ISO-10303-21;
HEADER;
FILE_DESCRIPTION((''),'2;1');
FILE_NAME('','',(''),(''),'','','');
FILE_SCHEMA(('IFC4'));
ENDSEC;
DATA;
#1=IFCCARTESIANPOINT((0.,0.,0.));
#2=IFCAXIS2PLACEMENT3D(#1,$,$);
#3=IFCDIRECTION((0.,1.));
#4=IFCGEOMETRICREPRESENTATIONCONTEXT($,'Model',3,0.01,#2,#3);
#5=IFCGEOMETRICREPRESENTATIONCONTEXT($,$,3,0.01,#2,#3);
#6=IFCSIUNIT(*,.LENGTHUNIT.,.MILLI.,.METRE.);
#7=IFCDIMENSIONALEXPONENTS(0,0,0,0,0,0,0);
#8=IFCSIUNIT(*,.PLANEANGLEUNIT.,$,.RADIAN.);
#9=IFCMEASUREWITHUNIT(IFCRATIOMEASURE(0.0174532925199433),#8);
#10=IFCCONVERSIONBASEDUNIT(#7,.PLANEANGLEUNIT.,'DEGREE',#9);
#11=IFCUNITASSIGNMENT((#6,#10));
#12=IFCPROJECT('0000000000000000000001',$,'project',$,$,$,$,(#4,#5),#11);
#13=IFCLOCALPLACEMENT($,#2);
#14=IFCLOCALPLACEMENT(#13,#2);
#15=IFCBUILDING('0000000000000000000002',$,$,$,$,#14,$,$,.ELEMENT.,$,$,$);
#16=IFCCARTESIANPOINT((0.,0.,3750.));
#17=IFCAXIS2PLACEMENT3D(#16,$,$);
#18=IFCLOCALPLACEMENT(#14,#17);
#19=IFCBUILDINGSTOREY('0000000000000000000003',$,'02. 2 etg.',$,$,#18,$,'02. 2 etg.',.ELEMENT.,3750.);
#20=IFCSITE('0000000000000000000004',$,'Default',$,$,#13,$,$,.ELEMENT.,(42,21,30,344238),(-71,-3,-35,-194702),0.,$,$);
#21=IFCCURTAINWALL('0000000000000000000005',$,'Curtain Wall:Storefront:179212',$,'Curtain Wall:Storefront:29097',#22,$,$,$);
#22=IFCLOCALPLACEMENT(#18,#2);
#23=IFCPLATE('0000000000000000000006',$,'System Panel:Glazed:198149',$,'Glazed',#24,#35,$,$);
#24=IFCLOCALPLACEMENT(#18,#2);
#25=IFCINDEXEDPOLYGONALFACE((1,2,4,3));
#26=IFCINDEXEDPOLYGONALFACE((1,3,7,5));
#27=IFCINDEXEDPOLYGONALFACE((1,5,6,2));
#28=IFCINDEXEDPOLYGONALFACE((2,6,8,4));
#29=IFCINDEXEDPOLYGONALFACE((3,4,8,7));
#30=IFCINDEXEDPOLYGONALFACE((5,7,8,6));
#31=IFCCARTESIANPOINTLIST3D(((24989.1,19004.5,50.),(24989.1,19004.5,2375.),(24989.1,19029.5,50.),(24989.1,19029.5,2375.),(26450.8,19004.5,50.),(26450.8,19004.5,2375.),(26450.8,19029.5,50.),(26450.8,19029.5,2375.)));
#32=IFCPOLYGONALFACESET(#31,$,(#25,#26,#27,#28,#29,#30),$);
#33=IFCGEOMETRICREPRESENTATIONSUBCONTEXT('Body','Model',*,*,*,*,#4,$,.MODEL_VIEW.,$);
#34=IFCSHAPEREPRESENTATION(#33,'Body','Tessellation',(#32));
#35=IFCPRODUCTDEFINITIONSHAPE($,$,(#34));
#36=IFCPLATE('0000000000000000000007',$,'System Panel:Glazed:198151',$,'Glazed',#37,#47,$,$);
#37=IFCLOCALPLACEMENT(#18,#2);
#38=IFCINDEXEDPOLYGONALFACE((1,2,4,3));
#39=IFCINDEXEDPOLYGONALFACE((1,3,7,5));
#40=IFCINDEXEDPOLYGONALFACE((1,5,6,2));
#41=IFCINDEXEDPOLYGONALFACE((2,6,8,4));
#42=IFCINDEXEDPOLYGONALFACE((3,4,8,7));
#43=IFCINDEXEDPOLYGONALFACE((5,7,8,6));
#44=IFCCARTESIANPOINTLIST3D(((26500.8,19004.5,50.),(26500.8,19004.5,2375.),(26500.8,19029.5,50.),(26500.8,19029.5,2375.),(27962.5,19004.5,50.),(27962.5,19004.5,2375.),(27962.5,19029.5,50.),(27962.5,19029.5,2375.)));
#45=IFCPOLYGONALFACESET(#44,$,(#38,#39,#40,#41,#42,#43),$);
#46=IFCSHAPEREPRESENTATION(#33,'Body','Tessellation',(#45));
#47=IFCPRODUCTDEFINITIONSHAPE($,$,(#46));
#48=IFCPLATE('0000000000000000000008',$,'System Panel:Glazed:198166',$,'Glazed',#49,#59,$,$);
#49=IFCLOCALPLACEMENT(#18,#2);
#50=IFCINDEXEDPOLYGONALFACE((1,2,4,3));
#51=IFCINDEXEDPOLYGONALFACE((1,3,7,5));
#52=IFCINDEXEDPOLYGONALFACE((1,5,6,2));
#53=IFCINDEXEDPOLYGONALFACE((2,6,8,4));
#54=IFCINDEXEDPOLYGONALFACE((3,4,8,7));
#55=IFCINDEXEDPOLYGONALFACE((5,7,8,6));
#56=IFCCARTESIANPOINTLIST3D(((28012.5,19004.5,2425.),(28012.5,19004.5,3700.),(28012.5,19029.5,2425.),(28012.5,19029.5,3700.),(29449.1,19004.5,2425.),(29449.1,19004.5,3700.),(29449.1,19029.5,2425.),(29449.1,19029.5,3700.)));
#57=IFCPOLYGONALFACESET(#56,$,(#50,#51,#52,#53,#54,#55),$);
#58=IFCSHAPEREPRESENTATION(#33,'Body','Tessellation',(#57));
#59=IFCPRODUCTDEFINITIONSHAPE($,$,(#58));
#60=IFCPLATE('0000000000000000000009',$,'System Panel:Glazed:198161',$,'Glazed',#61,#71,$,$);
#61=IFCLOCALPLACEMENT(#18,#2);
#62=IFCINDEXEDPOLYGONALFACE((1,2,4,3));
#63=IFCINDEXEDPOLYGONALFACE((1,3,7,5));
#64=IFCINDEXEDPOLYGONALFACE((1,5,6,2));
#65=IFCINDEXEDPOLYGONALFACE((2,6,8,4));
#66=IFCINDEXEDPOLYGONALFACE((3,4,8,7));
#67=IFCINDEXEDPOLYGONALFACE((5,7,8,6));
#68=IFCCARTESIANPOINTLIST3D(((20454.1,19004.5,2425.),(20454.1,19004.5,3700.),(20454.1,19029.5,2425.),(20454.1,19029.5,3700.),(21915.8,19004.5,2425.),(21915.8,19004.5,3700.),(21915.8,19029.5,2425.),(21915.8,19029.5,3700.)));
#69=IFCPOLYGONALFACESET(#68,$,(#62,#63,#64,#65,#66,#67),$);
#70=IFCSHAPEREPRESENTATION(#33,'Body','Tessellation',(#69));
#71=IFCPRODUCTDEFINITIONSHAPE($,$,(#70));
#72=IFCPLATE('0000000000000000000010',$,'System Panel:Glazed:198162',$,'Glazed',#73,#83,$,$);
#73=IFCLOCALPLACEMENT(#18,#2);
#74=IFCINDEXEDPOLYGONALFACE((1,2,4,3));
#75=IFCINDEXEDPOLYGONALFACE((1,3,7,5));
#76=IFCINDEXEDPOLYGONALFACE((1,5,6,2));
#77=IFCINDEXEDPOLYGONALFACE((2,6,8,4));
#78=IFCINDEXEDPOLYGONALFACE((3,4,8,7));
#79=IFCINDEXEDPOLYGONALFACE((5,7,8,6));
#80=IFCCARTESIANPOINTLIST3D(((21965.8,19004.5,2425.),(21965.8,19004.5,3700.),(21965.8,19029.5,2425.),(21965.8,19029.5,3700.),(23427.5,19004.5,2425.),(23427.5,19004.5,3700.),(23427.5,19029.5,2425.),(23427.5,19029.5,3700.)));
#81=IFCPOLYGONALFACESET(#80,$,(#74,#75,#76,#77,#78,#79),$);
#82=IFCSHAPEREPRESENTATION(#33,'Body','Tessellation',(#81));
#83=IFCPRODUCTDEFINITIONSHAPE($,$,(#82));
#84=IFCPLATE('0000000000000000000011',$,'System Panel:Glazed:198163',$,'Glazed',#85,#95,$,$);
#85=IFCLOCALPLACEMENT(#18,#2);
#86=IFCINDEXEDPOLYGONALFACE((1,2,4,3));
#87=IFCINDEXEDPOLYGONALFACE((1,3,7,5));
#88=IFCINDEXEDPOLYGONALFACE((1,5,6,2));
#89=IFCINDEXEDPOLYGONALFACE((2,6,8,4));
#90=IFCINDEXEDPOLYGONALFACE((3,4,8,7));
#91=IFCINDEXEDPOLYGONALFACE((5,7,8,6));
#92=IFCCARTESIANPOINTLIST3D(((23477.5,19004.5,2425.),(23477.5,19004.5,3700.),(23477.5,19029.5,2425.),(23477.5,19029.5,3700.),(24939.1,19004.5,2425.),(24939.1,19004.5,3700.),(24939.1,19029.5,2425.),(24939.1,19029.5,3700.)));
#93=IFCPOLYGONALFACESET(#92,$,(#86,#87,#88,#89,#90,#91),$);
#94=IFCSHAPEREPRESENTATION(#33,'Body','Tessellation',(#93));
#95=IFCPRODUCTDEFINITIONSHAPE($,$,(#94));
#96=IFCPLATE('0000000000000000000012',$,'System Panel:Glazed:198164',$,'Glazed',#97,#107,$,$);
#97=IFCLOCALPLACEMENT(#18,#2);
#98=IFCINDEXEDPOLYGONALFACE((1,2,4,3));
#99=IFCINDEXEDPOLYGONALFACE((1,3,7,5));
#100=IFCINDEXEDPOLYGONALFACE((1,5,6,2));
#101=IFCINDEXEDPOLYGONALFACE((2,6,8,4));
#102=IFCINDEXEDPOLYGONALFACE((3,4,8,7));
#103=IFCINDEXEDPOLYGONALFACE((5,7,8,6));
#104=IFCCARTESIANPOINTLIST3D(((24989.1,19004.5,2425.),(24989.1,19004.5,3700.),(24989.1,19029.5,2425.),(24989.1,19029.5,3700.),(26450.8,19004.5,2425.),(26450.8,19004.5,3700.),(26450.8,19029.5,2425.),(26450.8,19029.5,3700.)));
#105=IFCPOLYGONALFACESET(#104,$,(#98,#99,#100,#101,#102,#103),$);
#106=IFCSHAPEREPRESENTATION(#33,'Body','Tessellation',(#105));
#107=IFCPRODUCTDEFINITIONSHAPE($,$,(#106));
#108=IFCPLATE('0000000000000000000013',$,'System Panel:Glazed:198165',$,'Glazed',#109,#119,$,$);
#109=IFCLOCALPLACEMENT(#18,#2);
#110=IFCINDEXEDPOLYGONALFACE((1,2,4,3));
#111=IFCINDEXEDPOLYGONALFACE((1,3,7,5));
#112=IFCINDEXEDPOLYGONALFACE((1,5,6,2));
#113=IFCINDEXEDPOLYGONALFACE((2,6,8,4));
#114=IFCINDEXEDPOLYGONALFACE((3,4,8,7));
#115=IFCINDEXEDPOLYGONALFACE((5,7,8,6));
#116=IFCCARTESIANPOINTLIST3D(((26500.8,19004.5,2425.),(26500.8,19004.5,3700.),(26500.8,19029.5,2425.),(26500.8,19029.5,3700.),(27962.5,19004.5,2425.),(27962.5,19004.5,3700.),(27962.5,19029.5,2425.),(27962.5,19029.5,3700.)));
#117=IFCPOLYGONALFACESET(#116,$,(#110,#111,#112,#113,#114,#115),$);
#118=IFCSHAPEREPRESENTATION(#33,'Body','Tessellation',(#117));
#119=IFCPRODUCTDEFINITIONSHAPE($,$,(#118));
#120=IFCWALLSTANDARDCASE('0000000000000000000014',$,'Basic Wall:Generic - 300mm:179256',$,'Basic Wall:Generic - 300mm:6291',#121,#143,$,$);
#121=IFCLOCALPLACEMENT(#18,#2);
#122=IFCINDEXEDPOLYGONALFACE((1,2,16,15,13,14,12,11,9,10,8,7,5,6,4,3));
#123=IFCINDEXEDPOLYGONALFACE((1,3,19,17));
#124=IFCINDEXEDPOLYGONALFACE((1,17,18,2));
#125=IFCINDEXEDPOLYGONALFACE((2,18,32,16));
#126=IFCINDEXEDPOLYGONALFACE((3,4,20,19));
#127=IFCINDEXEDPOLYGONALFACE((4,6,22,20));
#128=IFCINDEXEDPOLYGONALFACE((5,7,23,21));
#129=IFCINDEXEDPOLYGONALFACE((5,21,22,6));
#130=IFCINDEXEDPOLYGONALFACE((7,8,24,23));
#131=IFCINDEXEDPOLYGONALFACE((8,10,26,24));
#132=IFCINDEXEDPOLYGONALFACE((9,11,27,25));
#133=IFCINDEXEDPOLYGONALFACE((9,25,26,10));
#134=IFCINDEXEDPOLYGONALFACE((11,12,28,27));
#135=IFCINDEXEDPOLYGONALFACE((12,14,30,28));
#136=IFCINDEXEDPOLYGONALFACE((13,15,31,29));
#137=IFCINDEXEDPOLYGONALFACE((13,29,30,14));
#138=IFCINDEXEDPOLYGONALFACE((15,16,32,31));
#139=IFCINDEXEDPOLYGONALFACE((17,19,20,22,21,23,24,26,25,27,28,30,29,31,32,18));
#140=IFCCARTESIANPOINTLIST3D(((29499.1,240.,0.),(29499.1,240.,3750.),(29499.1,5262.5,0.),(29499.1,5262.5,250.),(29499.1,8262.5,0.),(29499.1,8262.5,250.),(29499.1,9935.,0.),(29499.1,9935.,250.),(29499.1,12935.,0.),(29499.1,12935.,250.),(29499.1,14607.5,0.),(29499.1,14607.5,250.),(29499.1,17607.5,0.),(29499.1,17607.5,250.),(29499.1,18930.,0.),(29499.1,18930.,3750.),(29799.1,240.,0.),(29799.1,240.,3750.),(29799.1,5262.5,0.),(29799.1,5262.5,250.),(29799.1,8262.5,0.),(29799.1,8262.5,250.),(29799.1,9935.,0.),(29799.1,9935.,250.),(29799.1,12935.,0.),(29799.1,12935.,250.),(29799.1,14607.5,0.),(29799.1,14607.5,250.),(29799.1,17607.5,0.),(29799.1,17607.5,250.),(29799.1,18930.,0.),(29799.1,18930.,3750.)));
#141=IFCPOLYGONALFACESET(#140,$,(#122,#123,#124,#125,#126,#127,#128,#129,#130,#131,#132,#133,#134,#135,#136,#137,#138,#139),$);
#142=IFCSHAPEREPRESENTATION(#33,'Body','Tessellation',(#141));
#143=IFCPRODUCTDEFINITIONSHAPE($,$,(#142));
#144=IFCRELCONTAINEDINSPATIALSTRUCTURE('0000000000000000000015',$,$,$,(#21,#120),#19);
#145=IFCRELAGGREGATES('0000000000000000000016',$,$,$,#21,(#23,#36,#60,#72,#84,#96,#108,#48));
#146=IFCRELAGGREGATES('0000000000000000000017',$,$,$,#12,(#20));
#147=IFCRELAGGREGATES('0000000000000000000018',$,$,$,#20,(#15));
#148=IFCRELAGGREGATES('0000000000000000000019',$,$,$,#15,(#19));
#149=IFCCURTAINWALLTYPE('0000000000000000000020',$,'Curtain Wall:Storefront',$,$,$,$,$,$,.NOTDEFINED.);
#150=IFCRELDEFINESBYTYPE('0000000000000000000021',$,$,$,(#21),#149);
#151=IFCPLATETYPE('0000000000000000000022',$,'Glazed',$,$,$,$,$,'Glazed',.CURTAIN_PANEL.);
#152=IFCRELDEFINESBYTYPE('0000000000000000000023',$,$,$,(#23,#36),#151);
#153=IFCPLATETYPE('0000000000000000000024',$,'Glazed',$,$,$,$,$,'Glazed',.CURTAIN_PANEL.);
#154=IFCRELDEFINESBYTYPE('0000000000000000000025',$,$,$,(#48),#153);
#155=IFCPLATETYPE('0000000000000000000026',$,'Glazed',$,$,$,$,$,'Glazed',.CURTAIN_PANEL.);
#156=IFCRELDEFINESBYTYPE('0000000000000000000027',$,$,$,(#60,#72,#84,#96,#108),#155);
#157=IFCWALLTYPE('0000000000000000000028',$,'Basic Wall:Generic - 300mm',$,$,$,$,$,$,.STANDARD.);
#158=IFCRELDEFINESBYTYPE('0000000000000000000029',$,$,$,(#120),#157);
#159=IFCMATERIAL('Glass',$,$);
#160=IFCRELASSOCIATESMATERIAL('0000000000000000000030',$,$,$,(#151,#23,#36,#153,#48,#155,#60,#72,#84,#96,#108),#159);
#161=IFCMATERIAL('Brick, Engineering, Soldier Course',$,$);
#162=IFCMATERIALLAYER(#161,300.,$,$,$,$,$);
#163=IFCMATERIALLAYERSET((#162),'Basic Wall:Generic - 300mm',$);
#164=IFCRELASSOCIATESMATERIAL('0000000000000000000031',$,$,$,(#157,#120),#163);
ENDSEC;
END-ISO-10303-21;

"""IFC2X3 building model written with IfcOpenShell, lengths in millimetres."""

from ifc_helpers import new_model, entity, si_unit, converted_unit, direction, frame, frame_2d, origin, origin_2d_with_axis, place, context, subcontext, project, spatial, rectangle, extrude, clip, halfspace, source, transform, mapped, material, layer, layer_set, layer_usage, type_object, type_shapes, element, aggregate, save


model = new_model("IFC2X3")

# Units and contexts
model_context = context("Model", 3, precision=0.01, world=origin(), true_north=direction((0.0, 1.0)))
context_of_model = context(None, 3, precision=0.01, world=origin(), true_north=direction((0.0, 1.0)))
body_context = subcontext(model_context, "Body", "Model", "MODEL_VIEW")
ifc_project = project(units=[si_unit("LENGTHUNIT", "METRE", prefix="MILLI"), converted_unit("PLANEANGLEUNIT", "DEGREE", entity("IfcRatioMeasure", 0.0174532925199433), si_unit("PLANEANGLEUNIT", "RADIAN"), dimensions=[0, 0, 0, 0, 0, 0, 0])], contexts=[model_context, context_of_model])

# Site, building, storey
site_placement = place(None, origin())
site = spatial("IfcSite", under=ifc_project, at=site_placement, Name="Default", CompositionType="ELEMENT", RefLatitude=(42, 21, 30, 344238), RefLongitude=(-71, -3, -35, -194702), RefElevation=0.0)
building_placement = place(site_placement, origin())
building = spatial("IfcBuilding", under=site, at=building_placement, CompositionType="ELEMENT")
storey_placement = place(building_placement, frame((0.0, 0.0, 3750.0)))
storey = spatial("IfcBuildingStorey", under=building, at=storey_placement, Name="02. 2 etg.", LongName="02. 2 etg.", CompositionType="ELEMENT", Elevation=3750.0)

# Curtain wall, plates
curtain_wall_type = type_object("IfcCurtainWallType", Name="Curtain Wall:Storefront", PredefinedType="NOTDEFINED")
curtain_wall_placement = place(storey_placement, frame((0.0, 0.0, -3750.0)))
curtain_wall = element("IfcCurtainWall", 1, at=curtain_wall_placement, inside=storey, type_object=curtain_wall_type, Name="Curtain Wall:Storefront:179212", ObjectType="Curtain Wall:Storefront:29097")
ifc_material_1 = material(Name="Glass")
plate_type_1 = type_object("IfcPlateType", Name="Glazed", ElementType="Glazed", PredefinedType="CURTAIN_PANEL", material=ifc_material_1)
shared_shape_1 = source(origin(), body_context, "Body", "SweptSolid", [
    extrude(rectangle(XDim=25.0, YDim=1461.7, at=origin_2d_with_axis()), frame((730.8, 12.5, 0.0), z_axis=(0.0, 0.0, 1.0), x_axis=(0.0, 1.0, 0.0)), (0.0, 0.0, 1.0), 2325.0),
])
type_shapes(plate_type_1, [shared_shape_1])
plate_1_placement = place(curtain_wall_placement, frame((24989.1, 19004.5, 3800.0)))
plate_1 = element("IfcPlate", 2, at=plate_1_placement, type_object=plate_type_1, material=ifc_material_1, Name="System Panel:Glazed:198149", ObjectType="Glazed", context=body_context, shape_type="MappedRepresentation", body=[
    mapped(shared_shape_1, transform((0.0, 0.0, 0.0), scale=1.0)),
])
plate_2_placement = place(curtain_wall_placement, frame((26500.8, 19004.5, 3800.0)))
plate_2 = element("IfcPlate", 3, at=plate_2_placement, type_object=plate_type_1, material=ifc_material_1, Name="System Panel:Glazed:198151", ObjectType="Glazed", context=body_context, shape_type="MappedRepresentation", body=[
    mapped(shared_shape_1, transform((0.0, 0.0, 0.0), scale=1.0)),
])
plate_type_2 = type_object("IfcPlateType", Name="Glazed", ElementType="Glazed", PredefinedType="CURTAIN_PANEL", material=ifc_material_1)
shared_shape_2 = source(origin(), body_context, "Body", "SweptSolid", [
    extrude(rectangle(XDim=25.0, YDim=1436.7, at=origin_2d_with_axis()), frame((718.3, 12.5, 0.0), z_axis=(0.0, 0.0, 1.0), x_axis=(0.0, 1.0, 0.0)), (0.0, 0.0, 1.0), 1275.0),
])
type_shapes(plate_type_2, [shared_shape_2])
plate_3_placement = place(curtain_wall_placement, frame((28012.5, 19004.5, 6175.0)))
plate_3 = element("IfcPlate", 4, at=plate_3_placement, type_object=plate_type_2, material=ifc_material_1, Name="System Panel:Glazed:198166", ObjectType="Glazed", context=body_context, shape_type="MappedRepresentation", body=[
    mapped(shared_shape_2, transform((0.0, 0.0, 0.0), scale=1.0)),
])
plate_type_3 = type_object("IfcPlateType", Name="Glazed", ElementType="Glazed", PredefinedType="CURTAIN_PANEL", material=ifc_material_1)
shared_shape_3 = source(origin(), body_context, "Body", "SweptSolid", [
    extrude(rectangle(XDim=25.0, YDim=1461.7, at=origin_2d_with_axis()), frame((730.8, 12.5, 0.0), z_axis=(0.0, 0.0, 1.0), x_axis=(0.0, 1.0, 0.0)), (0.0, 0.0, 1.0), 1275.0),
])
type_shapes(plate_type_3, [shared_shape_3])
plate_4_placement = place(curtain_wall_placement, frame((20454.1, 19004.5, 6175.0)))
plate_4 = element("IfcPlate", 5, at=plate_4_placement, type_object=plate_type_3, material=ifc_material_1, Name="System Panel:Glazed:198161", ObjectType="Glazed", context=body_context, shape_type="MappedRepresentation", body=[
    mapped(shared_shape_3, transform((0.0, 0.0, 0.0), scale=1.0)),
])
plate_5_placement = place(curtain_wall_placement, frame((21965.8, 19004.5, 6175.0)))
plate_5 = element("IfcPlate", 6, at=plate_5_placement, type_object=plate_type_3, material=ifc_material_1, Name="System Panel:Glazed:198162", ObjectType="Glazed", context=body_context, shape_type="MappedRepresentation", body=[
    mapped(shared_shape_3, transform((0.0, 0.0, 0.0), scale=1.0)),
])
plate_6_placement = place(curtain_wall_placement, frame((23477.5, 19004.5, 6175.0)))
plate_6 = element("IfcPlate", 7, at=plate_6_placement, type_object=plate_type_3, material=ifc_material_1, Name="System Panel:Glazed:198163", ObjectType="Glazed", context=body_context, shape_type="MappedRepresentation", body=[
    mapped(shared_shape_3, transform((0.0, 0.0, 0.0), scale=1.0)),
])
plate_7_placement = place(curtain_wall_placement, frame((24989.1, 19004.5, 6175.0)))
plate_7 = element("IfcPlate", 8, at=plate_7_placement, type_object=plate_type_3, material=ifc_material_1, Name="System Panel:Glazed:198164", ObjectType="Glazed", context=body_context, shape_type="MappedRepresentation", body=[
    mapped(shared_shape_3, transform((0.0, 0.0, 0.0), scale=1.0)),
])
plate_8_placement = place(curtain_wall_placement, frame((26500.8, 19004.5, 6175.0)))
plate_8 = element("IfcPlate", 9, at=plate_8_placement, type_object=plate_type_3, material=ifc_material_1, Name="System Panel:Glazed:198165", ObjectType="Glazed", context=body_context, shape_type="MappedRepresentation", body=[
    mapped(shared_shape_3, transform((0.0, 0.0, 0.0), scale=1.0)),
])
aggregate(curtain_wall, [plate_1, plate_2, plate_4, plate_5, plate_6, plate_7, plate_8, plate_3])

# Wall, openings
ifc_material_2 = material(Name="Brick, Engineering, Soldier Course")
ifc_layer = layer(ifc_material_2, 300.0)
ifc_layer_set = layer_set([ifc_layer], Name="Basic Wall:Generic - 300mm")
ifc_layer_usage = layer_usage(ifc_layer_set, "AXIS2", "NEGATIVE", 150.0)
wall_type = type_object("IfcWallType", Name="Basic Wall:Generic - 300mm", PredefinedType="STANDARD", material=ifc_layer_set)
wall_placement = place(storey_placement, frame((29649.1, 18930.0, 0.0), z_axis=(0.0, 0.0, 1.0), x_axis=(0.0, -1.0, 0.0)))
wall = element("IfcWallStandardCase", 10, at=wall_placement, inside=storey, type_object=wall_type, material=ifc_layer_usage, Name="Basic Wall:Generic - 300mm:179256", ObjectType="Basic Wall:Generic - 300mm:6291", context=body_context, shape_type="Clipping", body=[
    clip(extrude(rectangle(XDim=18690.0, YDim=300.0, at=frame_2d((9345.0, 0.0), x_axis=(-1.0, 0.0))), origin(), (0.0, 0.0, 1.0), 3750.0), halfspace(frame((0.0, 0.0, -3750.0)), True)),
])
placement_1 = place(building_placement, origin())
placement_2 = place(placement_1, frame((29649.1, 18930.0, 0.0), z_axis=(0.0, 0.0, 1.0), x_axis=(0.0, -1.0, 0.0)))
opening_1_placement = place(placement_2, frame((4322.5, 150.0, 0.0)))
element("IfcOpeningElement", 11, at=opening_1_placement, cuts=wall, ObjectType="Opening", context=body_context, shape_type="SweptSolid", body=[
    extrude(rectangle(XDim=4000.0, YDim=3000.0, at=frame_2d((2000.0, 1500.0), x_axis=(1.0, 0.0))), frame((0.0, 0.0, 0.0), z_axis=(0.0, -1.0, 0.0), x_axis=(0.0, 0.0, 1.0)), (0.0, 0.0, 1.0), 300.0),
])
opening_2_placement = place(placement_2, frame((8995.0, 150.0, 0.0)))
element("IfcOpeningElement", 12, at=opening_2_placement, cuts=wall, ObjectType="Opening", context=body_context, shape_type="SweptSolid", body=[
    extrude(rectangle(XDim=4000.0, YDim=3000.0, at=frame_2d((2000.0, 1500.0), x_axis=(1.0, 0.0))), frame((0.0, 0.0, 0.0), z_axis=(0.0, -1.0, 0.0), x_axis=(0.0, 0.0, 1.0)), (0.0, 0.0, 1.0), 300.0),
])
opening_3_placement = place(placement_2, frame((13667.5, 150.0, 0.0)))
element("IfcOpeningElement", 13, at=opening_3_placement, cuts=wall, ObjectType="Opening", context=body_context, shape_type="SweptSolid", body=[
    extrude(rectangle(XDim=4000.0, YDim=3000.0, at=frame_2d((2000.0, 1500.0), x_axis=(1.0, 0.0))), frame((0.0, 0.0, 0.0), z_axis=(0.0, -1.0, 0.0), x_axis=(0.0, 0.0, 1.0)), (0.0, 0.0, 1.0), 300.0),
])

save(model, "model.ifc")
